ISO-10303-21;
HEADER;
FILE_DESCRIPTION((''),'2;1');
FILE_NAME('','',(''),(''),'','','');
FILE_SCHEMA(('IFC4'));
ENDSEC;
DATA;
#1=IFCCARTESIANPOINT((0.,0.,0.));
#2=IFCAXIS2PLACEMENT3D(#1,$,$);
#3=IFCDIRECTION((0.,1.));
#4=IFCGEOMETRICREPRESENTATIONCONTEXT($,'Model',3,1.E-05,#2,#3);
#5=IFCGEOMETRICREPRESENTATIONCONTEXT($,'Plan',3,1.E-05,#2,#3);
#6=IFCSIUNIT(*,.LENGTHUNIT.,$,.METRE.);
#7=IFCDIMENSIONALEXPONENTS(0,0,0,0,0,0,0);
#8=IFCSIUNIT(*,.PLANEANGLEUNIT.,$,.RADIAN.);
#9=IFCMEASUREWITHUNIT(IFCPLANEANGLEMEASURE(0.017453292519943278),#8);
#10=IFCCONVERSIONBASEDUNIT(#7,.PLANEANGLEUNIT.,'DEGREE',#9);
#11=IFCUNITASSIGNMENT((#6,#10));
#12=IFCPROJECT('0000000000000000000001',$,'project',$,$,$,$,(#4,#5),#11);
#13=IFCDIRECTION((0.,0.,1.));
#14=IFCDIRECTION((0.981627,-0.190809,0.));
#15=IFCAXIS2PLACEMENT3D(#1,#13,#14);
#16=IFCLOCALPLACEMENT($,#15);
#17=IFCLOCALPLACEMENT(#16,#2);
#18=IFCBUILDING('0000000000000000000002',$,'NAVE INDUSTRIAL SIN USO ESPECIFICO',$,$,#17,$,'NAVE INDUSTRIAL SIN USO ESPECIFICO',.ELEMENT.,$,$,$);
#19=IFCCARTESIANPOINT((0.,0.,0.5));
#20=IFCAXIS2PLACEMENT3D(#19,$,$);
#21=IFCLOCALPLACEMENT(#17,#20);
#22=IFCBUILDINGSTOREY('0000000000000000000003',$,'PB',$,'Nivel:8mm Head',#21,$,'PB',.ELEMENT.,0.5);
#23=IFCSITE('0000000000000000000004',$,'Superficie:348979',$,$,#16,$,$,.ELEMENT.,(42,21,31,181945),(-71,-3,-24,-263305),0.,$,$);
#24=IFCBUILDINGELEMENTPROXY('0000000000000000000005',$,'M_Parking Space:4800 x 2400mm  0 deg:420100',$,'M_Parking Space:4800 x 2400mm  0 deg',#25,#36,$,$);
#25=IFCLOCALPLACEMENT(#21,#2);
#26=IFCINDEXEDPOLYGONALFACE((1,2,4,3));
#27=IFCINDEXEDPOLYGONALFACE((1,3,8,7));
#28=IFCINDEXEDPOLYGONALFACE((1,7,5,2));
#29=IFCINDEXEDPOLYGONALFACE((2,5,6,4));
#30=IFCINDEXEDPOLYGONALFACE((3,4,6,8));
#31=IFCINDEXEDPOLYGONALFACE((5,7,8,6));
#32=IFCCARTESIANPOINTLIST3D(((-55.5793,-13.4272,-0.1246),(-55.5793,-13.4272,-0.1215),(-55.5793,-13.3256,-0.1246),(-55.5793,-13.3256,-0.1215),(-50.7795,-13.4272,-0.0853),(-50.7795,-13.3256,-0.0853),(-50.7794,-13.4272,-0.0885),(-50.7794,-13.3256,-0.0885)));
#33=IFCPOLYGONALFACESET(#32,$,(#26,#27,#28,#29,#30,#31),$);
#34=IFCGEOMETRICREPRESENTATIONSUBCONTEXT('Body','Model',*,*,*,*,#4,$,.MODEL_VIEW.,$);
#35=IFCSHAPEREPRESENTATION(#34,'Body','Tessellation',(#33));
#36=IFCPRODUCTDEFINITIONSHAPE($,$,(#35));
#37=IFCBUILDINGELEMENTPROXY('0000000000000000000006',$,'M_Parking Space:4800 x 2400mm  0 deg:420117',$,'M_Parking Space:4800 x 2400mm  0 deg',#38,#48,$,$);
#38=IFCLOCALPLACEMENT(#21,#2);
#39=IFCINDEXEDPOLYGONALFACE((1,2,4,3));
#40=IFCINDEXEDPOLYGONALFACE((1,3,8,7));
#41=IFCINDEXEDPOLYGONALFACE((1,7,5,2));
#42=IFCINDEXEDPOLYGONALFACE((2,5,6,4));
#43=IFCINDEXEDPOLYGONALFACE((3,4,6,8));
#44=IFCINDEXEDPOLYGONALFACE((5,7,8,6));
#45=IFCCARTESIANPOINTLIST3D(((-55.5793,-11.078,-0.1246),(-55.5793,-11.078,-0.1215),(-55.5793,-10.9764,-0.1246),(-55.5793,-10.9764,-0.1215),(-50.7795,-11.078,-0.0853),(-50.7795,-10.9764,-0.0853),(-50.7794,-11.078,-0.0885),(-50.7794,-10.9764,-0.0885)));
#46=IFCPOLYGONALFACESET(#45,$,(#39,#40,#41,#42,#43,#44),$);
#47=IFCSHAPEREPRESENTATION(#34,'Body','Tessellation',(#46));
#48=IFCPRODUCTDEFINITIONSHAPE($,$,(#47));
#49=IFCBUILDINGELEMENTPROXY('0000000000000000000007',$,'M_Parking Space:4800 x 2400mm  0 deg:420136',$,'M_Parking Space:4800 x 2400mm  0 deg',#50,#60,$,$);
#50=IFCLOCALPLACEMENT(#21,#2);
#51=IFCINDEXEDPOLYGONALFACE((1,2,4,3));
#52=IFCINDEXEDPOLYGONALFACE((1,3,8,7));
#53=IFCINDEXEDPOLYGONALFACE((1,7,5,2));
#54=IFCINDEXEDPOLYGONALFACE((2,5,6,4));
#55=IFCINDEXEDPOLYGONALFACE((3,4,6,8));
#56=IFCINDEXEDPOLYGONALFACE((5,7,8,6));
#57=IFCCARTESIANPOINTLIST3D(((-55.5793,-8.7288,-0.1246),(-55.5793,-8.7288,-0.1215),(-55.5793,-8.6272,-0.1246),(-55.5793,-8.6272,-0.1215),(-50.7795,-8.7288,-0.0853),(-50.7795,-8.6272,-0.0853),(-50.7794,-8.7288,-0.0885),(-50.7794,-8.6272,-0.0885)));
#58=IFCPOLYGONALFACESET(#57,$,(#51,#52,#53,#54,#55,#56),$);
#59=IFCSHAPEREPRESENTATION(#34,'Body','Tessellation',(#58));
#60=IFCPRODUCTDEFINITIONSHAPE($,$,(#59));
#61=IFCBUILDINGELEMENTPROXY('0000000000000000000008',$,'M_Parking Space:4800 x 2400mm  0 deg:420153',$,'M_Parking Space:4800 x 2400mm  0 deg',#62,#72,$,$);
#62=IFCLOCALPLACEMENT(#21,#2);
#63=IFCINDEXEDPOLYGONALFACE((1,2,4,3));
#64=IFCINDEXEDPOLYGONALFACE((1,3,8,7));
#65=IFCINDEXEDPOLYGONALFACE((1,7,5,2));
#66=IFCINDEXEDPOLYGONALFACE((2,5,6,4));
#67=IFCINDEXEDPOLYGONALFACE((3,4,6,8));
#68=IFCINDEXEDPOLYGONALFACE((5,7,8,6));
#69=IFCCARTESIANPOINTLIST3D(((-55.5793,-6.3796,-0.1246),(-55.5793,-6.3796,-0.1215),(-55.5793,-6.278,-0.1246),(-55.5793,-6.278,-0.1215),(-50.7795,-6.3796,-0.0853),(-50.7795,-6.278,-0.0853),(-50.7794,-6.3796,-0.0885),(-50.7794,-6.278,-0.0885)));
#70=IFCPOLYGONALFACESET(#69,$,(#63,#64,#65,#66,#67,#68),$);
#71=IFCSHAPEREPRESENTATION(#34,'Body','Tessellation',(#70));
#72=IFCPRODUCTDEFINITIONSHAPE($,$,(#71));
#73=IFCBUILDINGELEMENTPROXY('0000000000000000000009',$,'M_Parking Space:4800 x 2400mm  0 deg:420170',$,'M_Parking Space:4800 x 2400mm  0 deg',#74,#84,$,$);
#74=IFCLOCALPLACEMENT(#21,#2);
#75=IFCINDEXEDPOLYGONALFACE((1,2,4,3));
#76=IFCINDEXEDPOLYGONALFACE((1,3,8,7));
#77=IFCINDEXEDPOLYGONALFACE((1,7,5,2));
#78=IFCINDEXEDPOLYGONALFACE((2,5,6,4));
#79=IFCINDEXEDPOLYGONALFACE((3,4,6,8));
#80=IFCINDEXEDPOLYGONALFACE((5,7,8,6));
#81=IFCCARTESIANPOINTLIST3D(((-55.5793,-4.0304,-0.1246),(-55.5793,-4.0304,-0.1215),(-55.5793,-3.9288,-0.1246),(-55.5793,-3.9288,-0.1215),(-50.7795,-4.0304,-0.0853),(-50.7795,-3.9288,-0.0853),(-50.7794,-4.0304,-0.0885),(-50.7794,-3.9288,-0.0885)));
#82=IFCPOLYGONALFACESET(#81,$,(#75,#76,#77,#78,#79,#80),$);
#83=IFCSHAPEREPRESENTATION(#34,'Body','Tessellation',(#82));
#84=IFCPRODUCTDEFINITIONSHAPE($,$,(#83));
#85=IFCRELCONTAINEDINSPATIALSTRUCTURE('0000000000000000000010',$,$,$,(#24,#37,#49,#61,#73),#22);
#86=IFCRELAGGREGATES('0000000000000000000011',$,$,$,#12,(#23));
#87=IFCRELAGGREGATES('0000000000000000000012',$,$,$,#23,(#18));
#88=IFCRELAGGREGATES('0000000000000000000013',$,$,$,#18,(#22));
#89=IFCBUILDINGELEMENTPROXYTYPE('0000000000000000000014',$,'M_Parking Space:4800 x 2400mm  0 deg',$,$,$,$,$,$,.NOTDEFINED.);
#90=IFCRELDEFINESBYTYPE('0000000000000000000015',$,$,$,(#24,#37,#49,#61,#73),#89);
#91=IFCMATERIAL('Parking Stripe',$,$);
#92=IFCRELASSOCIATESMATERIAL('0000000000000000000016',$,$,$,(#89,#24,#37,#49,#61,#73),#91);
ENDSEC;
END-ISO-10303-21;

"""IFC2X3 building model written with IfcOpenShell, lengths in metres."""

from ifc_helpers import new_model, entity, si_unit, converted_unit, direction, frame, origin, origin_2d_with_axis, place, context, subcontext, project, spatial, rectangle, extrude, source, transform, mapped, material, type_object, type_shapes, element, save


model = new_model("IFC2X3")

# Units and contexts
model_context = context("Model", 3, precision=1e-05, world=origin(), true_north=direction((0.0, 1.0)))
plan_context = context("Plan", 3, precision=1e-05, world=origin(), true_north=direction((0.0, 1.0)))
body_context = subcontext(model_context, "Body", "Model", "MODEL_VIEW")
ifc_project = project(units=[si_unit("LENGTHUNIT", "METRE"), converted_unit("PLANEANGLEUNIT", "DEGREE", entity("IfcPlaneAngleMeasure", 0.017453292519943278), si_unit("PLANEANGLEUNIT", "RADIAN"), dimensions=[0, 0, 0, 0, 0, 0, 0])], contexts=[model_context, plan_context])

# Site, building, storey
site_placement = place(None, frame((0.0, 0.0, 0.0), z_axis=(0.0, 0.0, 1.0), x_axis=(0.981627, -0.190809, 0.0)))
site = spatial("IfcSite", under=ifc_project, at=site_placement, Name="Superficie:348979", CompositionType="ELEMENT", RefLatitude=(42, 21, 31, 181945), RefLongitude=(-71, -3, -24, -263305), RefElevation=0.0)
building_placement = place(site_placement, origin())
building = spatial("IfcBuilding", under=site, at=building_placement, Name="NAVE INDUSTRIAL SIN USO ESPECIFICO", LongName="NAVE INDUSTRIAL SIN USO ESPECIFICO", CompositionType="ELEMENT")
storey_placement = place(building_placement, frame((0.0, 0.0, 0.5)))
storey = spatial("IfcBuildingStorey", under=building, at=storey_placement, Name="PB", ObjectType="Nivel:8mm Head", LongName="PB", CompositionType="ELEMENT", Elevation=0.5)

# Building element proxies
ifc_material_1 = material(Name="Parking Stripe")
building_element_proxy_type_1 = type_object("IfcBuildingElementProxyType", Name="M_Parking Space:4800 x 2400mm  0 deg", PredefinedType="NOTDEFINED", material=ifc_material_1)
shared_shape_1 = source(origin(), body_context, "Body", "SweptSolid", [
    extrude(rectangle(XDim=0.1016, YDim=4.8, at=origin_2d_with_axis()), frame((0.0, 2.4, 0.0)), (0.0, 0.0, 1.0), 0.0032),
])
type_shapes(building_element_proxy_type_1, [shared_shape_1])
for number, where, z_axis, x_axis, name in (
    (1, (-50.7794, -13.3764, -0.0885), (-0.007536, 0.0, 0.999972), (0.0, 1.0, 0.0), "M_Parking Space:4800 x 2400mm  0 deg:420100"),
    (2, (-50.7794, -11.0272, -0.0885), (-0.007536, 0.0, 0.999972), (0.0, 1.0, 0.0), "M_Parking Space:4800 x 2400mm  0 deg:420117"),
    (3, (-50.7794, -8.678, -0.0885), (-0.007536, 0.0, 0.999972), (0.0, 1.0, 0.0), "M_Parking Space:4800 x 2400mm  0 deg:420136"),
    (4, (-50.7794, -6.3288, -0.0885), (-0.007536, 0.0, 0.999972), (0.0, 1.0, 0.0), "M_Parking Space:4800 x 2400mm  0 deg:420153"),
    (5, (-50.7794, -3.9796, -0.0885), (-0.007536, 0.0, 0.999972), (0.0, 1.0, 0.0), "M_Parking Space:4800 x 2400mm  0 deg:420170"),
):
    element("IfcBuildingElementProxy", number, at=place(storey_placement, frame(where, z_axis=z_axis, x_axis=x_axis)), inside=storey, type_object=building_element_proxy_type_1, material=ifc_material_1, Name=name, ObjectType="M_Parking Space:4800 x 2400mm  0 deg", context=body_context, shape_type="MappedRepresentation", body=[
        mapped(shared_shape_1, transform((0.0, 0.0, 0.0), scale=1.0)),
    ])

save(model, "model.ifc")
